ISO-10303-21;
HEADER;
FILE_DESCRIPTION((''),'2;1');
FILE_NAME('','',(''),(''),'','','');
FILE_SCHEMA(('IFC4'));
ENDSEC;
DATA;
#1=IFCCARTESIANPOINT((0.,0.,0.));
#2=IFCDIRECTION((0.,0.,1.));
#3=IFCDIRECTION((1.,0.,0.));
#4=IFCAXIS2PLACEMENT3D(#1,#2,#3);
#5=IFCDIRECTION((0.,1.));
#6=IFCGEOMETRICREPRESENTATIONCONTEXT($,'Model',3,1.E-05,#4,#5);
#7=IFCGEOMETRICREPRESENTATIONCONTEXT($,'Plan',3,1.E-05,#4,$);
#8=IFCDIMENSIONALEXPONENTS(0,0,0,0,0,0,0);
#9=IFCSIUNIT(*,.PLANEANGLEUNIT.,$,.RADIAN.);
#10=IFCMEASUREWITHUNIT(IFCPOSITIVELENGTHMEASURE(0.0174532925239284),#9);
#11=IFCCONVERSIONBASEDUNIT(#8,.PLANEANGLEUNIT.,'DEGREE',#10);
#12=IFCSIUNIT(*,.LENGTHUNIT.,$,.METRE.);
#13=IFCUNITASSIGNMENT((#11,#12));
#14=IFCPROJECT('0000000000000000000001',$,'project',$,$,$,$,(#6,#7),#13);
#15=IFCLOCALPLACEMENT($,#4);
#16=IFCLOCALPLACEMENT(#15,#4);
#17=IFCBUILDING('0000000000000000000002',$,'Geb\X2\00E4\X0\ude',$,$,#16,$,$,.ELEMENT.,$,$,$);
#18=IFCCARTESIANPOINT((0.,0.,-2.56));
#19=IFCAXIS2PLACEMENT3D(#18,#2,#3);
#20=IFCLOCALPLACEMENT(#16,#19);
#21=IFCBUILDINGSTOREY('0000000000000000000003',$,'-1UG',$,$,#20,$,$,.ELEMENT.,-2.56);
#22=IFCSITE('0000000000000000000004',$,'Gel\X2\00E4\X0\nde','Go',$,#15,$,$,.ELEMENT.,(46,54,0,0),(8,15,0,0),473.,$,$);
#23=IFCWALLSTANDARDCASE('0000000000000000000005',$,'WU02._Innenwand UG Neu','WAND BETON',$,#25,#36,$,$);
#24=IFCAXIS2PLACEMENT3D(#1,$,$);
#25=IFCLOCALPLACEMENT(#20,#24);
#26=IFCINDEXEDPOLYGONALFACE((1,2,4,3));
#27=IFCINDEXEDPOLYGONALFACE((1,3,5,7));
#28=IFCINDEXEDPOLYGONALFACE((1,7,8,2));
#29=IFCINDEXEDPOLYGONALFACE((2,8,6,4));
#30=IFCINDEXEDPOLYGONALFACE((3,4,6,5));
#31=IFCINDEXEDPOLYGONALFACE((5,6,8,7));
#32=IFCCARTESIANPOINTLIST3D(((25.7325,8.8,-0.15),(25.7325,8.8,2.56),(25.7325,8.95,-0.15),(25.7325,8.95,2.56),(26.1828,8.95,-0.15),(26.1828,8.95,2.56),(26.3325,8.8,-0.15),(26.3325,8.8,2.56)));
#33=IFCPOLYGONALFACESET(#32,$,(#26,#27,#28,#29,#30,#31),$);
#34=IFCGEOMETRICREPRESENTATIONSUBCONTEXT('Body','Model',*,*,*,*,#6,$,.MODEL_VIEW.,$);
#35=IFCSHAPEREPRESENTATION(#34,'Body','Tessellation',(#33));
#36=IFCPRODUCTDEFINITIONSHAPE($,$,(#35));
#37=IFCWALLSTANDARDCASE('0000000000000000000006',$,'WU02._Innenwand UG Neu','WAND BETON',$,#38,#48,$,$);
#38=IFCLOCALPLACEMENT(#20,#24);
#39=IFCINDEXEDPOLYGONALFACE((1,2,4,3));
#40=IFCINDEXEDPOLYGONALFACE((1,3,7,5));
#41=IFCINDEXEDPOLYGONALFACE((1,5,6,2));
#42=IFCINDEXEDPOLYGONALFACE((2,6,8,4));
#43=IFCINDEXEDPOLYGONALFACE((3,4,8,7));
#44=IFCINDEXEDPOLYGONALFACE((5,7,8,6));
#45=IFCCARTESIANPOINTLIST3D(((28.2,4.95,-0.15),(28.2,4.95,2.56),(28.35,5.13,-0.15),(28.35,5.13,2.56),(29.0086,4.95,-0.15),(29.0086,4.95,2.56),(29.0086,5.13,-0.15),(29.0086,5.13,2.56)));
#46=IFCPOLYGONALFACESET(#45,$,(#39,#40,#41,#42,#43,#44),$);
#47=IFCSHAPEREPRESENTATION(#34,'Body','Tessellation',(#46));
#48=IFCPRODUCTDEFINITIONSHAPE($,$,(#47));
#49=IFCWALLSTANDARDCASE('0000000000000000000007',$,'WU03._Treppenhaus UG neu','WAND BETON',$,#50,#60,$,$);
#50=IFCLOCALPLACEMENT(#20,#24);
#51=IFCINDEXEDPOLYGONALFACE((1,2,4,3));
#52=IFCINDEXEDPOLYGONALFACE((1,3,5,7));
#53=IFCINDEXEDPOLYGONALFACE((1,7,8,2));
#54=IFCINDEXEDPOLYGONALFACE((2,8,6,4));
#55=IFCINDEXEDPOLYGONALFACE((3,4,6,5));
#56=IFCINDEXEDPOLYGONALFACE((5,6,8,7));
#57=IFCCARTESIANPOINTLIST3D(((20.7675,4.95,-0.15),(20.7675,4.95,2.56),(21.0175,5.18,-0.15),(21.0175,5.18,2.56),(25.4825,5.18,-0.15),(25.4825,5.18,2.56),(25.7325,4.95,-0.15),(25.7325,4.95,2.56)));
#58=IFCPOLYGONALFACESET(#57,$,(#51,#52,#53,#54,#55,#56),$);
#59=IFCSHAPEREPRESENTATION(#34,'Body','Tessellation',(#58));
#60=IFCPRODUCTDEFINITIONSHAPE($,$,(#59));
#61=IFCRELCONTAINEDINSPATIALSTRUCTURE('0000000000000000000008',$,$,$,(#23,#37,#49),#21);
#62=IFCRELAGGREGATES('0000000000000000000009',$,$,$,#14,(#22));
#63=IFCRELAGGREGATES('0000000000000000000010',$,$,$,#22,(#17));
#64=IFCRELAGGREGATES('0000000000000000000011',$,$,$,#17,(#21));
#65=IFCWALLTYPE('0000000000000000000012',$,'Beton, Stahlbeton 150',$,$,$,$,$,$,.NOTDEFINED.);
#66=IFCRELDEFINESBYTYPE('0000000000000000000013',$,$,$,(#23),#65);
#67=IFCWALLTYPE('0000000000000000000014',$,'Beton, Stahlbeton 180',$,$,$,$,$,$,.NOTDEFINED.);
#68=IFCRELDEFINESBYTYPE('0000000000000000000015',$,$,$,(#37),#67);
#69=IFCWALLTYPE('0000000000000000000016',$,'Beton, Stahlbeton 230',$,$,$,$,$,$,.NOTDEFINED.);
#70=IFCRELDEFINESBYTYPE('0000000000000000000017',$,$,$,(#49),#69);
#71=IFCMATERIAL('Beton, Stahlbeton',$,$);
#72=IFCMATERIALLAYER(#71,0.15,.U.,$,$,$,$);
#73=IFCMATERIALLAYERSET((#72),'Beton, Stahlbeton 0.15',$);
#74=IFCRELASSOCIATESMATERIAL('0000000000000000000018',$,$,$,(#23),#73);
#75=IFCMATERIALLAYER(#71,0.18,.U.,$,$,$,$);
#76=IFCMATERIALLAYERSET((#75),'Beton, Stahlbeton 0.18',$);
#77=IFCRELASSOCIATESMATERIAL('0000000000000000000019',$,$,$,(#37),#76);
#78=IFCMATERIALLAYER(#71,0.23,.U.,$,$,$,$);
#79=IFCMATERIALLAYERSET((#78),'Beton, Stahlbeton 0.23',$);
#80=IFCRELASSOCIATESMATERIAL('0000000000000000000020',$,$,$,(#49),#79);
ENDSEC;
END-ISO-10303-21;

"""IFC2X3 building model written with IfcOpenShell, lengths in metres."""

from ifc_helpers import new_model, entity, si_unit, converted_unit, direction, frame, origin_with_axes, place, context, subcontext, project, spatial, polyline, outline, extrude, material, layer, layer_set, layer_usage, type_object, element, save


model = new_model("IFC2X3")

# Units and contexts
model_context = context("Model", 3, precision=1e-05, world=origin_with_axes(), true_north=direction((0.0, 1.0)))
plan_context = context("Plan", 3, precision=1e-05, world=origin_with_axes())
body_context = subcontext(model_context, "Body", "Model", "MODEL_VIEW")
ifc_project = project(units=[converted_unit("PLANEANGLEUNIT", "DEGREE", entity("IfcPositiveLengthMeasure", 0.0174532925239284), si_unit("PLANEANGLEUNIT", "RADIAN"), dimensions=[0, 0, 0, 0, 0, 0, 0]), si_unit("LENGTHUNIT", "METRE")], contexts=[model_context, plan_context])

# Site, building, storey
site_placement = place(None, origin_with_axes())
site = spatial("IfcSite", under=ifc_project, at=site_placement, Name="Gelände", Description="Go", CompositionType="ELEMENT", RefLatitude=(46, 54, 0, 0), RefLongitude=(8, 15, 0, 0), RefElevation=473.0)
building_placement = place(site_placement, origin_with_axes())
building = spatial("IfcBuilding", under=site, at=building_placement, Name="Gebäude", CompositionType="ELEMENT")
storey_placement = place(building_placement, frame((0.0, 0.0, -2.56), z_axis=(0.0, 0.0, 1.0), x_axis=(1.0, 0.0, 0.0)))
storey = spatial("IfcBuildingStorey", under=building, at=storey_placement, Name="-1UG", CompositionType="ELEMENT", Elevation=-2.56)

# Shared definitions
ifc_material_1 = material(Name="Beton, Stahlbeton")

# Walls
ifc_layer_1 = layer(ifc_material_1, 0.15, ventilated="UNKNOWN")
ifc_layer_set_1 = layer_set([ifc_layer_1], Name="Beton, Stahlbeton 0.15")
wall_type_1 = type_object("IfcWallType", Name="Beton, Stahlbeton 150", PredefinedType="NOTDEFINED")
ifc_layer_usage_1 = layer_usage(ifc_layer_set_1, "AXIS2", "NEGATIVE", 0.0)
wall_1_placement = place(storey_placement, frame((26.3325, 8.8, -0.15), z_axis=(0.0, 0.0, 1.0), x_axis=(-1.0, 0.0, 0.0)))
element("IfcWallStandardCase", 1, at=wall_1_placement, inside=storey, type_object=wall_type_1, material=ifc_layer_usage_1, Name="WU02._Innenwand UG Neu", Description="WAND BETON", context=body_context, shape_type="SweptSolid", body=[
    extrude(outline(polyline([(0.1497, -0.15), (0.6, -0.15), (0.6, 0.0), (0.0, 0.0), (0.1497, -0.15)])), origin_with_axes(), (0.0, 0.0, 1.0), 2.71),
])
ifc_layer_2 = layer(ifc_material_1, 0.18, ventilated="UNKNOWN")
ifc_layer_set_2 = layer_set([ifc_layer_2], Name="Beton, Stahlbeton 0.18")
ifc_layer_usage_2 = layer_usage(ifc_layer_set_2, "AXIS2", "POSITIVE", 0.0)
wall_type_2 = type_object("IfcWallType", Name="Beton, Stahlbeton 180", PredefinedType="NOTDEFINED")
wall_2_placement = place(storey_placement, frame((28.2, 4.95, -0.15), z_axis=(0.0, 0.0, 1.0), x_axis=(1.0, 0.0, 0.0)))
element("IfcWallStandardCase", 2, at=wall_2_placement, inside=storey, type_object=wall_type_2, material=ifc_layer_usage_2, Name="WU02._Innenwand UG Neu", Description="WAND BETON", context=body_context, shape_type="SweptSolid", body=[
    extrude(outline(polyline([(0.0, 0.0), (0.8086, 0.0), (0.8086, 0.18), (0.15, 0.18), (0.0, 0.0)])), origin_with_axes(), (0.0, 0.0, 1.0), 2.71),
])
ifc_layer_3 = layer(ifc_material_1, 0.23, ventilated="UNKNOWN")
ifc_layer_set_3 = layer_set([ifc_layer_3], Name="Beton, Stahlbeton 0.23")
ifc_layer_usage_3 = layer_usage(ifc_layer_set_3, "AXIS2", "NEGATIVE", 0.23)
wall_type_3 = type_object("IfcWallType", Name="Beton, Stahlbeton 230", PredefinedType="NOTDEFINED")
wall_3_placement = place(storey_placement, frame((25.4825, 5.18, -0.15), z_axis=(0.0, 0.0, 1.0), x_axis=(-1.0, 0.0, 0.0)))
element("IfcWallStandardCase", 3, at=wall_3_placement, inside=storey, type_object=wall_type_3, material=ifc_layer_usage_3, Name="WU03._Treppenhaus UG neu", Description="WAND BETON", context=body_context, shape_type="SweptSolid", body=[
    extrude(outline(polyline([(0.0, 0.0), (4.465, 0.0), (4.715, 0.23), (-0.25, 0.23), (0.0, 0.0)])), origin_with_axes(), (0.0, 0.0, 1.0), 2.71),
])

save(model, "model.ifc")
